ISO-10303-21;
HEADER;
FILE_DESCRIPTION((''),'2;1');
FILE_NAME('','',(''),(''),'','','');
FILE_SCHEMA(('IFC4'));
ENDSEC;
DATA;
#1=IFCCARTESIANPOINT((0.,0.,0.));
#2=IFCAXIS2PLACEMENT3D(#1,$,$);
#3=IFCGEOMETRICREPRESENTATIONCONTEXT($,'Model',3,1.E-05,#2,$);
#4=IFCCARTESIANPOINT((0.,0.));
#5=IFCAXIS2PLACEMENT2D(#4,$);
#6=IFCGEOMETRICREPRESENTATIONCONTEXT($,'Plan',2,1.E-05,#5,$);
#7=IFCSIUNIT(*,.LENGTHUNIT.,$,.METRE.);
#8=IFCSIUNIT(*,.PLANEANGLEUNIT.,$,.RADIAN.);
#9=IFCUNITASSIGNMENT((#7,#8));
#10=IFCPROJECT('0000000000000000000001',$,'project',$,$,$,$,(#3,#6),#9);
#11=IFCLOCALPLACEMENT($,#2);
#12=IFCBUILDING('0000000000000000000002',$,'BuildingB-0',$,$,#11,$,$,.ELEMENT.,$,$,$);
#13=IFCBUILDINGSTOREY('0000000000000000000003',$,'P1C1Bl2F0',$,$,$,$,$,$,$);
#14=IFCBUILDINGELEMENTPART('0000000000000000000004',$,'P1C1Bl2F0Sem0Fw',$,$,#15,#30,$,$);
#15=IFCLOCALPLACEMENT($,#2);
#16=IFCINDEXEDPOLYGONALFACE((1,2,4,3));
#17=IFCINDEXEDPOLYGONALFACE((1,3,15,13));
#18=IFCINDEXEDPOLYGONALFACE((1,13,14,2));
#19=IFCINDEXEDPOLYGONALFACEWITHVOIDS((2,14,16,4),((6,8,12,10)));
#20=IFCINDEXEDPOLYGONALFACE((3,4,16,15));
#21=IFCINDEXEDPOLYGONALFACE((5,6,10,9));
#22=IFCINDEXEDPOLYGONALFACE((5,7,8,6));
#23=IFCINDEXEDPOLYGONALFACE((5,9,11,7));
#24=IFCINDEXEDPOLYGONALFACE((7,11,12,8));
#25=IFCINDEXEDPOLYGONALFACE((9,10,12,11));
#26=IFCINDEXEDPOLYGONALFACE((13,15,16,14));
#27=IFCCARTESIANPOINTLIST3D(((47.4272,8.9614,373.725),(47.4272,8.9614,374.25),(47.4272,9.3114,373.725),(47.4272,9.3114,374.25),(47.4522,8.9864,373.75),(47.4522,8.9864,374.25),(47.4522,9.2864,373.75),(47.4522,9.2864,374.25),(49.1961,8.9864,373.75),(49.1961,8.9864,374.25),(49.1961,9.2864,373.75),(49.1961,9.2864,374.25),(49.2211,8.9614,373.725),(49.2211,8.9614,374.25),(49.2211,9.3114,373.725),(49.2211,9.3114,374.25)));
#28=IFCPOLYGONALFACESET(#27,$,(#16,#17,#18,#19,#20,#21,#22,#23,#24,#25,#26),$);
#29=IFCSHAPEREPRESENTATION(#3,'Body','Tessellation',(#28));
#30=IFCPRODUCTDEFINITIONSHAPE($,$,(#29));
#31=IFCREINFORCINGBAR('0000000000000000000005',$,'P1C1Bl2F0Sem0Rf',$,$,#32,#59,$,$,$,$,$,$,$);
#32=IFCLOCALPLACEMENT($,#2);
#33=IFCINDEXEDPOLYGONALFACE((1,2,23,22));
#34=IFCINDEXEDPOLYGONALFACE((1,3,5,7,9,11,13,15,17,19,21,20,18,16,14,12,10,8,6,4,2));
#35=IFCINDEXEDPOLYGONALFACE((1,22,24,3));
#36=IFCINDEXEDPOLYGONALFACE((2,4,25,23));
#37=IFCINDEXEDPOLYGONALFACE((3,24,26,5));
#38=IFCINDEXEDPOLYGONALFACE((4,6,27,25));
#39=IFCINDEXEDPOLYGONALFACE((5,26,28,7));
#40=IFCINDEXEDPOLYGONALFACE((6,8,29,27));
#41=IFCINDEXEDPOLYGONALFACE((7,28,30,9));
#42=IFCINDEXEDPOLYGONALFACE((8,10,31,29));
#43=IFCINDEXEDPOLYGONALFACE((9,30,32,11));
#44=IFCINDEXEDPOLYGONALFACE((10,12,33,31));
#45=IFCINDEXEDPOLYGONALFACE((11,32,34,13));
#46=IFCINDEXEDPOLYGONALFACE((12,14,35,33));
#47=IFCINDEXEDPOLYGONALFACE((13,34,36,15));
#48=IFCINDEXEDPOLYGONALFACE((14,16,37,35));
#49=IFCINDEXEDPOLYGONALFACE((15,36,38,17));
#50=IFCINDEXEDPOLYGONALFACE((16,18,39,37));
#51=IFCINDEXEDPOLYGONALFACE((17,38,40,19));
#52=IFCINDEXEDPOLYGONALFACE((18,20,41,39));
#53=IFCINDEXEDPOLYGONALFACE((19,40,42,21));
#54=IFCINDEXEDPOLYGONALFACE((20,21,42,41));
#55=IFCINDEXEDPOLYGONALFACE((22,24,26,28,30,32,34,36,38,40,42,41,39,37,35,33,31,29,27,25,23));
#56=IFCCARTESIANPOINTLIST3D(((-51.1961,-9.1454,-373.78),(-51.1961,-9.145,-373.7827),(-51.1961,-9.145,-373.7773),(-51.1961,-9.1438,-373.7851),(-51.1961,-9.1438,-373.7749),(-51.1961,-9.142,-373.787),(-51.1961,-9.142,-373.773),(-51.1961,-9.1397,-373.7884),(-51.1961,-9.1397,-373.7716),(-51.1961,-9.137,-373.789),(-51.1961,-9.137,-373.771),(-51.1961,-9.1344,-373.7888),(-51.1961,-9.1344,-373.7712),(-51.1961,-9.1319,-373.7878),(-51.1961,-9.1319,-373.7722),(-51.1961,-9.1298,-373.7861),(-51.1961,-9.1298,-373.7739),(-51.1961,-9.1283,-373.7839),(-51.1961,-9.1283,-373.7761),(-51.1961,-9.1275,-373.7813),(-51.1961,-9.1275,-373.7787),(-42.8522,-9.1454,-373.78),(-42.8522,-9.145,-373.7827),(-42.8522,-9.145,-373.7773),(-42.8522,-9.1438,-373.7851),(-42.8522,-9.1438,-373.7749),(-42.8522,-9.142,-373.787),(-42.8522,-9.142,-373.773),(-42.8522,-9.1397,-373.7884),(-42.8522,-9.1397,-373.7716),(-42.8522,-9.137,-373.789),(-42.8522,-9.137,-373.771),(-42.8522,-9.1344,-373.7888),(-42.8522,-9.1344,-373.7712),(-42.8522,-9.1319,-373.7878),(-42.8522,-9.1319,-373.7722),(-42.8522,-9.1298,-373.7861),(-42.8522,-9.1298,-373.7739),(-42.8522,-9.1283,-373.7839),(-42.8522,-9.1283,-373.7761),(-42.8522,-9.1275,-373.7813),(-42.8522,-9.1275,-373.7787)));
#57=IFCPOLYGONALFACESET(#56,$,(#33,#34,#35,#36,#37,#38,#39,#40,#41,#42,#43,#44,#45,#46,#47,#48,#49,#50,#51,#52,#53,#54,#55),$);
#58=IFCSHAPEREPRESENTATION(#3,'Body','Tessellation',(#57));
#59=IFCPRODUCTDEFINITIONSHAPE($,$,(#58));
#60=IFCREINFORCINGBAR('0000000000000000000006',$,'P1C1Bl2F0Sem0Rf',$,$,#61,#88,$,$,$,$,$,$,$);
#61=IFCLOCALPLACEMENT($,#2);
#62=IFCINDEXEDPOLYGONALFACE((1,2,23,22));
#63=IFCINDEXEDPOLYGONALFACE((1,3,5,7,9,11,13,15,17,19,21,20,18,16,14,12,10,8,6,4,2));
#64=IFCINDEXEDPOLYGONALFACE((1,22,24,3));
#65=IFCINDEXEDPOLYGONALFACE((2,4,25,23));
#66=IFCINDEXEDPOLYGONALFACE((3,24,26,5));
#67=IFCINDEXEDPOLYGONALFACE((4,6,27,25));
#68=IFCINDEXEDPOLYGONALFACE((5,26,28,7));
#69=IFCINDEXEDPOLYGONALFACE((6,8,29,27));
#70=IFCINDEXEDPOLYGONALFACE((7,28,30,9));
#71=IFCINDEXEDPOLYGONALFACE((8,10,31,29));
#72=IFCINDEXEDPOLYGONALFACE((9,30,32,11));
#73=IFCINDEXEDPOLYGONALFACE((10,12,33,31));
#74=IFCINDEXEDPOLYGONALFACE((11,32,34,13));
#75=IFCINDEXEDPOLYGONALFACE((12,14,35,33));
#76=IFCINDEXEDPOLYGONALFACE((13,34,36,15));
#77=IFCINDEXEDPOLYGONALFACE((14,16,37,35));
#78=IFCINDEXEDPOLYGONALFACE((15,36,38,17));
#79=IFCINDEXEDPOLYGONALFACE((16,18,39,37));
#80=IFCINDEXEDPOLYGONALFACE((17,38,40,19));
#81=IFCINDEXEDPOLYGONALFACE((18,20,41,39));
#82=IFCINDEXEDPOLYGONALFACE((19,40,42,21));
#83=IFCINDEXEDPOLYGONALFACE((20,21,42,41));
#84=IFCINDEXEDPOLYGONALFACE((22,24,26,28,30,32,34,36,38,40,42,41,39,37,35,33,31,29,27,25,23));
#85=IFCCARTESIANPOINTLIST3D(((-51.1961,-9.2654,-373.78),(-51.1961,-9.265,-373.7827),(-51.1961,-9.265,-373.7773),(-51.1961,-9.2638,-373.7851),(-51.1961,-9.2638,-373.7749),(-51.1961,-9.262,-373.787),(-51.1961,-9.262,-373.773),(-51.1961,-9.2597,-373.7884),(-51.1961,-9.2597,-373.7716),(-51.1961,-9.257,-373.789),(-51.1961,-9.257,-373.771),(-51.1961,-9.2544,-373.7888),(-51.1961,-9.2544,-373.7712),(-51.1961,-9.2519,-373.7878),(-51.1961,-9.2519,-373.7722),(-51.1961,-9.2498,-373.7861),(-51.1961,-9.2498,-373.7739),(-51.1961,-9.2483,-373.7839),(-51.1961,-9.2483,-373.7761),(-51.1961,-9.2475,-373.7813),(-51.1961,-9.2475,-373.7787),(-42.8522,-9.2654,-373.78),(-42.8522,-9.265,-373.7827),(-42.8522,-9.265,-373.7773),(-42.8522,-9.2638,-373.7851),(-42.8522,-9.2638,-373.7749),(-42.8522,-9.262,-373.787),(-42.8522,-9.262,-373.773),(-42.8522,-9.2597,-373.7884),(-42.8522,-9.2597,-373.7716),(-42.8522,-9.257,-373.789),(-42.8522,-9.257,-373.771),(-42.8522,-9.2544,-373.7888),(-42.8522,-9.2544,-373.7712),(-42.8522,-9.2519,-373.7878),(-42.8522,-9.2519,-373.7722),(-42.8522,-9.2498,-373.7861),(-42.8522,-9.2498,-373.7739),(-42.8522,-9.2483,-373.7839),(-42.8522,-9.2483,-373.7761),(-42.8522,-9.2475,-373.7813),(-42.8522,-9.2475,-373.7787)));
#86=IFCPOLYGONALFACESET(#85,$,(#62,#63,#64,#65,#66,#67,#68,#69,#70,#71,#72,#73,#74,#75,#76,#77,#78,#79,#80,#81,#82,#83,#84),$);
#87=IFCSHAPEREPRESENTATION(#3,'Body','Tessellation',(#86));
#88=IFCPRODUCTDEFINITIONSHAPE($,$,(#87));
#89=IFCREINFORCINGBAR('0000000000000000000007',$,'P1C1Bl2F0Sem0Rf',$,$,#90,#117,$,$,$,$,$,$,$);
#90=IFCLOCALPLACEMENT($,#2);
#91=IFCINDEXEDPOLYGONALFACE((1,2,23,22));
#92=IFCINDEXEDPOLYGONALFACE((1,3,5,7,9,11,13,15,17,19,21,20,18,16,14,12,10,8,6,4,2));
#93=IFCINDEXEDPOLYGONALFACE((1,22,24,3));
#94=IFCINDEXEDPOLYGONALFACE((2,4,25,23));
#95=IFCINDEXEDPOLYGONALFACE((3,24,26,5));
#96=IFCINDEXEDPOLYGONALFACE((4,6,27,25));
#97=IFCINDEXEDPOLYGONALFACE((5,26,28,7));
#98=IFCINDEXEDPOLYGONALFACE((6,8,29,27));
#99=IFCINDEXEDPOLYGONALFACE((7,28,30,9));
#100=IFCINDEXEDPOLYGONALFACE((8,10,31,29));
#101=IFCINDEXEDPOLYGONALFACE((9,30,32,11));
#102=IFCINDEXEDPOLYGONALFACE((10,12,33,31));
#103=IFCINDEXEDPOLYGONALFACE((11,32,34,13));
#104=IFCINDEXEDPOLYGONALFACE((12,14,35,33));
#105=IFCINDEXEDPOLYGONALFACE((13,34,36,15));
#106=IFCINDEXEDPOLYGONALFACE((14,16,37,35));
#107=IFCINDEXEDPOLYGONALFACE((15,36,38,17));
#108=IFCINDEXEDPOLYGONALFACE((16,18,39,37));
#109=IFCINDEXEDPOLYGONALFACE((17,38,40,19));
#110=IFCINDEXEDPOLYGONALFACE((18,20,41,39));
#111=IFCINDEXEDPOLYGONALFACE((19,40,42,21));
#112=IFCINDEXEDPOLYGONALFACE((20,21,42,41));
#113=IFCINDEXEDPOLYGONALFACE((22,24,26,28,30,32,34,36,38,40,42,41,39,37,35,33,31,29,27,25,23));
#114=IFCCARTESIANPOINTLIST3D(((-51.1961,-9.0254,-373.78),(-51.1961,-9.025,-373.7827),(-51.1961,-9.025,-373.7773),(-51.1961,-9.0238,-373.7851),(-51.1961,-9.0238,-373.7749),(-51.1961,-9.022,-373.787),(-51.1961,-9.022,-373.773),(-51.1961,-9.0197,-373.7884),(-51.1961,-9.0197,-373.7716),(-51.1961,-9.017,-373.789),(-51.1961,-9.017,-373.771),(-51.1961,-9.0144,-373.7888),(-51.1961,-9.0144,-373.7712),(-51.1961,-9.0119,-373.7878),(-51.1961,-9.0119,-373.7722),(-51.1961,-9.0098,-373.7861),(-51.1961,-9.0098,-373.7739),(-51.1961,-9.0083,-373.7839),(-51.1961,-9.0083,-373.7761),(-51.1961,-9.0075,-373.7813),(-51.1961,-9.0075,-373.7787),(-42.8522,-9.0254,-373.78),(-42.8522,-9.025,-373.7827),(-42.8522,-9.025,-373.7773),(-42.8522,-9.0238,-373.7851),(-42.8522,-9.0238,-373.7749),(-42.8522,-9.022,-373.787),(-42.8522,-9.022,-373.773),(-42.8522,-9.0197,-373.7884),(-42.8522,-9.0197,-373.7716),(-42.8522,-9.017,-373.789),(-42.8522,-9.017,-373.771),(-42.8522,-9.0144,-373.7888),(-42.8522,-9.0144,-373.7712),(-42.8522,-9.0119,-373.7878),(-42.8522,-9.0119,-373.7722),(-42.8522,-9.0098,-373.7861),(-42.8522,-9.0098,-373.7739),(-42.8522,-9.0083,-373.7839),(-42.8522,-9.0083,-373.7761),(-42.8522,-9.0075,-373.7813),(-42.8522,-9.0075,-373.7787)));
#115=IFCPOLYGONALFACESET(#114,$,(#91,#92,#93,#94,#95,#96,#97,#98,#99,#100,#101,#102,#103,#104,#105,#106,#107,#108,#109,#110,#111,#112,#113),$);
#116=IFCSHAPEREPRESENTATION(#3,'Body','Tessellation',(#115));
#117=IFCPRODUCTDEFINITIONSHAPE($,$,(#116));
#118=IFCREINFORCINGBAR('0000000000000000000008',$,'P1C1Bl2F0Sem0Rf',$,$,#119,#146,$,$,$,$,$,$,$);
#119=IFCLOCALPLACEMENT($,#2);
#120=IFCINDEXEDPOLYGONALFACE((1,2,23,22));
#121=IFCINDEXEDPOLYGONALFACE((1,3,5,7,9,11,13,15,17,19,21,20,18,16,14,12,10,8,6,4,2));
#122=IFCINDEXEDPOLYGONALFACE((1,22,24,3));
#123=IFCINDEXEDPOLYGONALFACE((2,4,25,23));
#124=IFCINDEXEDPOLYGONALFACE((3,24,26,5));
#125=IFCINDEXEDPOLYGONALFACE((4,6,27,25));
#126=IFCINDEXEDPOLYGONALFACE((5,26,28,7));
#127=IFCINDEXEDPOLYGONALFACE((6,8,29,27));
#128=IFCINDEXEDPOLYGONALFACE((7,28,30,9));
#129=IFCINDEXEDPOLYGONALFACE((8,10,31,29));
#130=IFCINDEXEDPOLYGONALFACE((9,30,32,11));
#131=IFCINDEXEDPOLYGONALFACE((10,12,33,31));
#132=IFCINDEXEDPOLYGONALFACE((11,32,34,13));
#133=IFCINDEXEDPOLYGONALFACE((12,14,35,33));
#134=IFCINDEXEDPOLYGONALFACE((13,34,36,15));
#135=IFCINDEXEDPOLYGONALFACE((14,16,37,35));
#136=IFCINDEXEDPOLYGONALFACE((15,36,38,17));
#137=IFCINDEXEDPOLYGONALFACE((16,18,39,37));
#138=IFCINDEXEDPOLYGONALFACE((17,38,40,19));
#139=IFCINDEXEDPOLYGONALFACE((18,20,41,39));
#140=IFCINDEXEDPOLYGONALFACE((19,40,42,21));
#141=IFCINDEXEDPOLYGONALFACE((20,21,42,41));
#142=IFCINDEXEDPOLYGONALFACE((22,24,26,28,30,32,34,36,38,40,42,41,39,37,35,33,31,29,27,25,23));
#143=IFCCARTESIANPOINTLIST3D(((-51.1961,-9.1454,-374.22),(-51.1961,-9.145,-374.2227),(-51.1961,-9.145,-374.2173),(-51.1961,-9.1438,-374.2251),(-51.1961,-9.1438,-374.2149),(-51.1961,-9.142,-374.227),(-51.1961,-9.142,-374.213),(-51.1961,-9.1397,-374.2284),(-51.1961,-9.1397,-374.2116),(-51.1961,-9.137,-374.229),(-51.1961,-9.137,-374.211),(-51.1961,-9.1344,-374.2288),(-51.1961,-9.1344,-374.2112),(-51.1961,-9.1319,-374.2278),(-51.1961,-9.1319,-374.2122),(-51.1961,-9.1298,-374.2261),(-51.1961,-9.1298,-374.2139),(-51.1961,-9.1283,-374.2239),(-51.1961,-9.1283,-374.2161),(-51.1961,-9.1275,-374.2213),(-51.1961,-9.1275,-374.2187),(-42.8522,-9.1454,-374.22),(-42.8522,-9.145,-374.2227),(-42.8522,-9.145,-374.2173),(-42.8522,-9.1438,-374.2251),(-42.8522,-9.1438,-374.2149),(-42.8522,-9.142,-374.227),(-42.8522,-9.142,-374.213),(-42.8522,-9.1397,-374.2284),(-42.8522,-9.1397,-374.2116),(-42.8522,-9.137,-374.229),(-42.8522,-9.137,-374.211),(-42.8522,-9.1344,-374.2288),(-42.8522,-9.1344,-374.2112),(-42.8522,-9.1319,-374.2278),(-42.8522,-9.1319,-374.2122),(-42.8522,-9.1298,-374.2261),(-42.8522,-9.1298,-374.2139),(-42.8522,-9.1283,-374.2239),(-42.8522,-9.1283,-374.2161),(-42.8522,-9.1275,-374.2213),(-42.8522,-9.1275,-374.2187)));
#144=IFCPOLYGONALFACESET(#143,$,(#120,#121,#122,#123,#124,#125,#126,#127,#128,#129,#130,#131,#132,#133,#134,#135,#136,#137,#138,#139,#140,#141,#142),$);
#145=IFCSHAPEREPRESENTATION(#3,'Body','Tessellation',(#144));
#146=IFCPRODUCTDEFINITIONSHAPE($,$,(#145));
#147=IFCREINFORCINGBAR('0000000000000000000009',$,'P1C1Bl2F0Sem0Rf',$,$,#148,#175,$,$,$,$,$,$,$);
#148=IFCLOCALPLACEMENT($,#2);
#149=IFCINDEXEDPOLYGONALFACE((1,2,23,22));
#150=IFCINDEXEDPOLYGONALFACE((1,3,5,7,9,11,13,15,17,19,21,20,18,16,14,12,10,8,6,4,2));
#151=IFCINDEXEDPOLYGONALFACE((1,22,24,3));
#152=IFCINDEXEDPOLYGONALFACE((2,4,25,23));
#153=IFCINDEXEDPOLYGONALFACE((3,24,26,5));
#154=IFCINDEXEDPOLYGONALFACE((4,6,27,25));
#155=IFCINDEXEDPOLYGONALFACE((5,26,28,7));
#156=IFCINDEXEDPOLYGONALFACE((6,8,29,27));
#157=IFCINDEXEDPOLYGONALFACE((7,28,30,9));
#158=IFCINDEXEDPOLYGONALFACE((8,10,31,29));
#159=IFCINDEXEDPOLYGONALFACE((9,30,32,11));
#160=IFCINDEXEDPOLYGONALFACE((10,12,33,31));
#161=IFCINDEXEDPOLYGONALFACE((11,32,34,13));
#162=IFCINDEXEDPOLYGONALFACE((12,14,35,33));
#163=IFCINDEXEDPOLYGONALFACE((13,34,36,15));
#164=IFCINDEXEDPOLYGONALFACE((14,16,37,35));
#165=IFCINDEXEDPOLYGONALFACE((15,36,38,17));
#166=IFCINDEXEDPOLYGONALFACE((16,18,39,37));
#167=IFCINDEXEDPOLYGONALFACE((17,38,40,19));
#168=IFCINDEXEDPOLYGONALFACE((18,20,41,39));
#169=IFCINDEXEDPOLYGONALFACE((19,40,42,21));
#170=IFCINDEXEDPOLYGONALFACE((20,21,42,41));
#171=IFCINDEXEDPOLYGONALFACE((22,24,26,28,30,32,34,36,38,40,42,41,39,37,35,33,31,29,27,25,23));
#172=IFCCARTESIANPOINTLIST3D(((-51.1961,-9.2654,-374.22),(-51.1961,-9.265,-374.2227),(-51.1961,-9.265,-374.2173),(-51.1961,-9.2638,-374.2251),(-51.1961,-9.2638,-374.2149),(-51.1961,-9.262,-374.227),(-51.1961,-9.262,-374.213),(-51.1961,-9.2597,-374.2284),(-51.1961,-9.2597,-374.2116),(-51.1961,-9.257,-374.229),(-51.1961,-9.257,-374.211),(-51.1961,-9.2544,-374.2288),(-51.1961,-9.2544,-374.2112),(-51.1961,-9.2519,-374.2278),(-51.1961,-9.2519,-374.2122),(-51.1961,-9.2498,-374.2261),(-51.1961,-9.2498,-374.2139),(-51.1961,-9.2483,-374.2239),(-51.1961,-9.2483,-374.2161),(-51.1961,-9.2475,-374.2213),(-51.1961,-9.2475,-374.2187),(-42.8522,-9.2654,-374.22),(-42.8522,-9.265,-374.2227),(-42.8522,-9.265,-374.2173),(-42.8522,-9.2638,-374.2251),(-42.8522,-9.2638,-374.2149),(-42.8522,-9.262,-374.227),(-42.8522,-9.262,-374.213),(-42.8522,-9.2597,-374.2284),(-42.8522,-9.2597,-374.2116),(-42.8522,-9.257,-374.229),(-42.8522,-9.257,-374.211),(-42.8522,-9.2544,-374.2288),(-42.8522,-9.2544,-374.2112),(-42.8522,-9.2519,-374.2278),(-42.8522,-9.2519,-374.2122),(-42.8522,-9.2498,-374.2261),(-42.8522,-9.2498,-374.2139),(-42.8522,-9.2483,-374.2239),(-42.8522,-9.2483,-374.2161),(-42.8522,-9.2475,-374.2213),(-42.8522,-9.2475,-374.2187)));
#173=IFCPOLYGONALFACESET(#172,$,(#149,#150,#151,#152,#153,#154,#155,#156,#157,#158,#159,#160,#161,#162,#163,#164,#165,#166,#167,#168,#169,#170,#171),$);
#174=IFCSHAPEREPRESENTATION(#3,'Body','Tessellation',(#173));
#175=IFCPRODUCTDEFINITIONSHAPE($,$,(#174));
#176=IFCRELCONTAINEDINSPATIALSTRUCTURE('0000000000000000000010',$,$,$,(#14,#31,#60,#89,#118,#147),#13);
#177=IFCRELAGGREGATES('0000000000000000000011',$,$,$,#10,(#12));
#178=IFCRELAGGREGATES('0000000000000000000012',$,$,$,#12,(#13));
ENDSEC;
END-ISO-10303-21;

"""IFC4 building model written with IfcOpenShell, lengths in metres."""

from ifc_helpers import new_model, entity, si_unit, origin, origin_2d, place, context, project, spatial, polyline, outline, extrude, element, save


model = new_model("IFC4")

# Units and contexts
model_context = context("Model", 3, precision=1e-05, world=origin())
plan_context = context("Plan", 2, precision=1e-05, world=origin_2d())
ifc_project = project(units=[si_unit("LENGTHUNIT", "METRE"), si_unit("PLANEANGLEUNIT", "RADIAN")], contexts=[model_context, plan_context])

# Building, storey
building_placement = place(None, origin())
building = spatial("IfcBuilding", under=ifc_project, at=building_placement, Name="BuildingB-0", CompositionType="ELEMENT")
storey = spatial("IfcBuildingStorey", under=building, Name="P1C1Bl2F0")

# Building element part, opening
building_element_part_1 = element("IfcBuildingElementPart", 1, inside=storey, Name="P1C1Bl2F0Sem0Fw", context=model_context, shape_type="SweptSolid", body=[
    extrude(outline(polyline([(47.4272, 8.9614, 373.725), (49.2211, 8.9614, 373.725), (49.2211, 9.3114, 373.725), (47.4272, 9.3114, 373.725), (47.4272, 8.9614, 373.725)])), None, (0.0, 0.0, 1.0), 0.525),
])
element("IfcOpeningElement", 2, inside=storey, cuts=building_element_part_1, context=model_context, shape_type="SweptSolid", body=[
    extrude(outline(polyline([(47.4522, 8.9864, 373.75), (49.1961, 8.9864, 373.75), (49.1961, 9.2864, 373.75), (47.4522, 9.2864, 373.75), (47.4522, 8.9864, 373.75)])), None, (0.0, 0.0, 1.0), 0.5),
])

# Reinforcing bars
element("IfcReinforcingBar", 3, inside=storey, Name="P1C1Bl2F0Sem0Rf", context=model_context, shape_type="SweptSolid", body=[
    entity("IfcSurfaceCurveSweptAreaSolid", entity("IfcCircleProfileDef", "AREA", None, None, 0.009), None, entity("IfcPolyline", [entity("IfcCartesianPoint", [51.1961, 9.1364, 373.78]), entity("IfcCartesianPoint", [42.8522, 9.1364, 373.78])]), None, None, entity("IfcPlane", entity("IfcAxis2Placement3D", entity("IfcCartesianPoint", [51.1961, 9.1364, 373.78]), entity("IfcDirection", [0.0, 0.0, 1.0]), entity("IfcDirection", [1.0, 0.0, 0.0])))),
])
element("IfcReinforcingBar", 4, inside=storey, Name="P1C1Bl2F0Sem0Rf", context=model_context, shape_type="SweptSolid", body=[
    entity("IfcSurfaceCurveSweptAreaSolid", entity("IfcCircleProfileDef", "AREA", None, None, 0.009), None, entity("IfcPolyline", [entity("IfcCartesianPoint", [51.1961, 9.2564, 373.78]), entity("IfcCartesianPoint", [42.8522, 9.2564, 373.78])]), None, None, entity("IfcPlane", entity("IfcAxis2Placement3D", entity("IfcCartesianPoint", [51.1961, 9.2564, 373.78]), entity("IfcDirection", [0.0, 0.0, 1.0]), entity("IfcDirection", [1.0, 0.0, 0.0])))),
])
element("IfcReinforcingBar", 5, inside=storey, Name="P1C1Bl2F0Sem0Rf", context=model_context, shape_type="SweptSolid", body=[
    entity("IfcSurfaceCurveSweptAreaSolid", entity("IfcCircleProfileDef", "AREA", None, None, 0.009), None, entity("IfcPolyline", [entity("IfcCartesianPoint", [51.1961, 9.0164, 373.78]), entity("IfcCartesianPoint", [42.8522, 9.0164, 373.78])]), None, None, entity("IfcPlane", entity("IfcAxis2Placement3D", entity("IfcCartesianPoint", [51.1961, 9.0164, 373.78]), entity("IfcDirection", [0.0, 0.0, 1.0]), entity("IfcDirection", [1.0, 0.0, 0.0])))),
])
element("IfcReinforcingBar", 6, inside=storey, Name="P1C1Bl2F0Sem0Rf", context=model_context, shape_type="SweptSolid", body=[
    entity("IfcSurfaceCurveSweptAreaSolid", entity("IfcCircleProfileDef", "AREA", None, None, 0.009), None, entity("IfcPolyline", [entity("IfcCartesianPoint", [51.1961, 9.1364, 374.22]), entity("IfcCartesianPoint", [42.8522, 9.1364, 374.22])]), None, None, entity("IfcPlane", entity("IfcAxis2Placement3D", entity("IfcCartesianPoint", [51.1961, 9.1364, 374.22]), entity("IfcDirection", [0.0, 0.0, 1.0]), entity("IfcDirection", [1.0, 0.0, 0.0])))),
])
element("IfcReinforcingBar", 7, inside=storey, Name="P1C1Bl2F0Sem0Rf", context=model_context, shape_type="SweptSolid", body=[
    entity("IfcSurfaceCurveSweptAreaSolid", entity("IfcCircleProfileDef", "AREA", None, None, 0.009), None, entity("IfcPolyline", [entity("IfcCartesianPoint", [51.1961, 9.2564, 374.22]), entity("IfcCartesianPoint", [42.8522, 9.2564, 374.22])]), None, None, entity("IfcPlane", entity("IfcAxis2Placement3D", entity("IfcCartesianPoint", [51.1961, 9.2564, 374.22]), entity("IfcDirection", [0.0, 0.0, 1.0]), entity("IfcDirection", [1.0, 0.0, 0.0])))),
])

save(model, "model.ifc")
